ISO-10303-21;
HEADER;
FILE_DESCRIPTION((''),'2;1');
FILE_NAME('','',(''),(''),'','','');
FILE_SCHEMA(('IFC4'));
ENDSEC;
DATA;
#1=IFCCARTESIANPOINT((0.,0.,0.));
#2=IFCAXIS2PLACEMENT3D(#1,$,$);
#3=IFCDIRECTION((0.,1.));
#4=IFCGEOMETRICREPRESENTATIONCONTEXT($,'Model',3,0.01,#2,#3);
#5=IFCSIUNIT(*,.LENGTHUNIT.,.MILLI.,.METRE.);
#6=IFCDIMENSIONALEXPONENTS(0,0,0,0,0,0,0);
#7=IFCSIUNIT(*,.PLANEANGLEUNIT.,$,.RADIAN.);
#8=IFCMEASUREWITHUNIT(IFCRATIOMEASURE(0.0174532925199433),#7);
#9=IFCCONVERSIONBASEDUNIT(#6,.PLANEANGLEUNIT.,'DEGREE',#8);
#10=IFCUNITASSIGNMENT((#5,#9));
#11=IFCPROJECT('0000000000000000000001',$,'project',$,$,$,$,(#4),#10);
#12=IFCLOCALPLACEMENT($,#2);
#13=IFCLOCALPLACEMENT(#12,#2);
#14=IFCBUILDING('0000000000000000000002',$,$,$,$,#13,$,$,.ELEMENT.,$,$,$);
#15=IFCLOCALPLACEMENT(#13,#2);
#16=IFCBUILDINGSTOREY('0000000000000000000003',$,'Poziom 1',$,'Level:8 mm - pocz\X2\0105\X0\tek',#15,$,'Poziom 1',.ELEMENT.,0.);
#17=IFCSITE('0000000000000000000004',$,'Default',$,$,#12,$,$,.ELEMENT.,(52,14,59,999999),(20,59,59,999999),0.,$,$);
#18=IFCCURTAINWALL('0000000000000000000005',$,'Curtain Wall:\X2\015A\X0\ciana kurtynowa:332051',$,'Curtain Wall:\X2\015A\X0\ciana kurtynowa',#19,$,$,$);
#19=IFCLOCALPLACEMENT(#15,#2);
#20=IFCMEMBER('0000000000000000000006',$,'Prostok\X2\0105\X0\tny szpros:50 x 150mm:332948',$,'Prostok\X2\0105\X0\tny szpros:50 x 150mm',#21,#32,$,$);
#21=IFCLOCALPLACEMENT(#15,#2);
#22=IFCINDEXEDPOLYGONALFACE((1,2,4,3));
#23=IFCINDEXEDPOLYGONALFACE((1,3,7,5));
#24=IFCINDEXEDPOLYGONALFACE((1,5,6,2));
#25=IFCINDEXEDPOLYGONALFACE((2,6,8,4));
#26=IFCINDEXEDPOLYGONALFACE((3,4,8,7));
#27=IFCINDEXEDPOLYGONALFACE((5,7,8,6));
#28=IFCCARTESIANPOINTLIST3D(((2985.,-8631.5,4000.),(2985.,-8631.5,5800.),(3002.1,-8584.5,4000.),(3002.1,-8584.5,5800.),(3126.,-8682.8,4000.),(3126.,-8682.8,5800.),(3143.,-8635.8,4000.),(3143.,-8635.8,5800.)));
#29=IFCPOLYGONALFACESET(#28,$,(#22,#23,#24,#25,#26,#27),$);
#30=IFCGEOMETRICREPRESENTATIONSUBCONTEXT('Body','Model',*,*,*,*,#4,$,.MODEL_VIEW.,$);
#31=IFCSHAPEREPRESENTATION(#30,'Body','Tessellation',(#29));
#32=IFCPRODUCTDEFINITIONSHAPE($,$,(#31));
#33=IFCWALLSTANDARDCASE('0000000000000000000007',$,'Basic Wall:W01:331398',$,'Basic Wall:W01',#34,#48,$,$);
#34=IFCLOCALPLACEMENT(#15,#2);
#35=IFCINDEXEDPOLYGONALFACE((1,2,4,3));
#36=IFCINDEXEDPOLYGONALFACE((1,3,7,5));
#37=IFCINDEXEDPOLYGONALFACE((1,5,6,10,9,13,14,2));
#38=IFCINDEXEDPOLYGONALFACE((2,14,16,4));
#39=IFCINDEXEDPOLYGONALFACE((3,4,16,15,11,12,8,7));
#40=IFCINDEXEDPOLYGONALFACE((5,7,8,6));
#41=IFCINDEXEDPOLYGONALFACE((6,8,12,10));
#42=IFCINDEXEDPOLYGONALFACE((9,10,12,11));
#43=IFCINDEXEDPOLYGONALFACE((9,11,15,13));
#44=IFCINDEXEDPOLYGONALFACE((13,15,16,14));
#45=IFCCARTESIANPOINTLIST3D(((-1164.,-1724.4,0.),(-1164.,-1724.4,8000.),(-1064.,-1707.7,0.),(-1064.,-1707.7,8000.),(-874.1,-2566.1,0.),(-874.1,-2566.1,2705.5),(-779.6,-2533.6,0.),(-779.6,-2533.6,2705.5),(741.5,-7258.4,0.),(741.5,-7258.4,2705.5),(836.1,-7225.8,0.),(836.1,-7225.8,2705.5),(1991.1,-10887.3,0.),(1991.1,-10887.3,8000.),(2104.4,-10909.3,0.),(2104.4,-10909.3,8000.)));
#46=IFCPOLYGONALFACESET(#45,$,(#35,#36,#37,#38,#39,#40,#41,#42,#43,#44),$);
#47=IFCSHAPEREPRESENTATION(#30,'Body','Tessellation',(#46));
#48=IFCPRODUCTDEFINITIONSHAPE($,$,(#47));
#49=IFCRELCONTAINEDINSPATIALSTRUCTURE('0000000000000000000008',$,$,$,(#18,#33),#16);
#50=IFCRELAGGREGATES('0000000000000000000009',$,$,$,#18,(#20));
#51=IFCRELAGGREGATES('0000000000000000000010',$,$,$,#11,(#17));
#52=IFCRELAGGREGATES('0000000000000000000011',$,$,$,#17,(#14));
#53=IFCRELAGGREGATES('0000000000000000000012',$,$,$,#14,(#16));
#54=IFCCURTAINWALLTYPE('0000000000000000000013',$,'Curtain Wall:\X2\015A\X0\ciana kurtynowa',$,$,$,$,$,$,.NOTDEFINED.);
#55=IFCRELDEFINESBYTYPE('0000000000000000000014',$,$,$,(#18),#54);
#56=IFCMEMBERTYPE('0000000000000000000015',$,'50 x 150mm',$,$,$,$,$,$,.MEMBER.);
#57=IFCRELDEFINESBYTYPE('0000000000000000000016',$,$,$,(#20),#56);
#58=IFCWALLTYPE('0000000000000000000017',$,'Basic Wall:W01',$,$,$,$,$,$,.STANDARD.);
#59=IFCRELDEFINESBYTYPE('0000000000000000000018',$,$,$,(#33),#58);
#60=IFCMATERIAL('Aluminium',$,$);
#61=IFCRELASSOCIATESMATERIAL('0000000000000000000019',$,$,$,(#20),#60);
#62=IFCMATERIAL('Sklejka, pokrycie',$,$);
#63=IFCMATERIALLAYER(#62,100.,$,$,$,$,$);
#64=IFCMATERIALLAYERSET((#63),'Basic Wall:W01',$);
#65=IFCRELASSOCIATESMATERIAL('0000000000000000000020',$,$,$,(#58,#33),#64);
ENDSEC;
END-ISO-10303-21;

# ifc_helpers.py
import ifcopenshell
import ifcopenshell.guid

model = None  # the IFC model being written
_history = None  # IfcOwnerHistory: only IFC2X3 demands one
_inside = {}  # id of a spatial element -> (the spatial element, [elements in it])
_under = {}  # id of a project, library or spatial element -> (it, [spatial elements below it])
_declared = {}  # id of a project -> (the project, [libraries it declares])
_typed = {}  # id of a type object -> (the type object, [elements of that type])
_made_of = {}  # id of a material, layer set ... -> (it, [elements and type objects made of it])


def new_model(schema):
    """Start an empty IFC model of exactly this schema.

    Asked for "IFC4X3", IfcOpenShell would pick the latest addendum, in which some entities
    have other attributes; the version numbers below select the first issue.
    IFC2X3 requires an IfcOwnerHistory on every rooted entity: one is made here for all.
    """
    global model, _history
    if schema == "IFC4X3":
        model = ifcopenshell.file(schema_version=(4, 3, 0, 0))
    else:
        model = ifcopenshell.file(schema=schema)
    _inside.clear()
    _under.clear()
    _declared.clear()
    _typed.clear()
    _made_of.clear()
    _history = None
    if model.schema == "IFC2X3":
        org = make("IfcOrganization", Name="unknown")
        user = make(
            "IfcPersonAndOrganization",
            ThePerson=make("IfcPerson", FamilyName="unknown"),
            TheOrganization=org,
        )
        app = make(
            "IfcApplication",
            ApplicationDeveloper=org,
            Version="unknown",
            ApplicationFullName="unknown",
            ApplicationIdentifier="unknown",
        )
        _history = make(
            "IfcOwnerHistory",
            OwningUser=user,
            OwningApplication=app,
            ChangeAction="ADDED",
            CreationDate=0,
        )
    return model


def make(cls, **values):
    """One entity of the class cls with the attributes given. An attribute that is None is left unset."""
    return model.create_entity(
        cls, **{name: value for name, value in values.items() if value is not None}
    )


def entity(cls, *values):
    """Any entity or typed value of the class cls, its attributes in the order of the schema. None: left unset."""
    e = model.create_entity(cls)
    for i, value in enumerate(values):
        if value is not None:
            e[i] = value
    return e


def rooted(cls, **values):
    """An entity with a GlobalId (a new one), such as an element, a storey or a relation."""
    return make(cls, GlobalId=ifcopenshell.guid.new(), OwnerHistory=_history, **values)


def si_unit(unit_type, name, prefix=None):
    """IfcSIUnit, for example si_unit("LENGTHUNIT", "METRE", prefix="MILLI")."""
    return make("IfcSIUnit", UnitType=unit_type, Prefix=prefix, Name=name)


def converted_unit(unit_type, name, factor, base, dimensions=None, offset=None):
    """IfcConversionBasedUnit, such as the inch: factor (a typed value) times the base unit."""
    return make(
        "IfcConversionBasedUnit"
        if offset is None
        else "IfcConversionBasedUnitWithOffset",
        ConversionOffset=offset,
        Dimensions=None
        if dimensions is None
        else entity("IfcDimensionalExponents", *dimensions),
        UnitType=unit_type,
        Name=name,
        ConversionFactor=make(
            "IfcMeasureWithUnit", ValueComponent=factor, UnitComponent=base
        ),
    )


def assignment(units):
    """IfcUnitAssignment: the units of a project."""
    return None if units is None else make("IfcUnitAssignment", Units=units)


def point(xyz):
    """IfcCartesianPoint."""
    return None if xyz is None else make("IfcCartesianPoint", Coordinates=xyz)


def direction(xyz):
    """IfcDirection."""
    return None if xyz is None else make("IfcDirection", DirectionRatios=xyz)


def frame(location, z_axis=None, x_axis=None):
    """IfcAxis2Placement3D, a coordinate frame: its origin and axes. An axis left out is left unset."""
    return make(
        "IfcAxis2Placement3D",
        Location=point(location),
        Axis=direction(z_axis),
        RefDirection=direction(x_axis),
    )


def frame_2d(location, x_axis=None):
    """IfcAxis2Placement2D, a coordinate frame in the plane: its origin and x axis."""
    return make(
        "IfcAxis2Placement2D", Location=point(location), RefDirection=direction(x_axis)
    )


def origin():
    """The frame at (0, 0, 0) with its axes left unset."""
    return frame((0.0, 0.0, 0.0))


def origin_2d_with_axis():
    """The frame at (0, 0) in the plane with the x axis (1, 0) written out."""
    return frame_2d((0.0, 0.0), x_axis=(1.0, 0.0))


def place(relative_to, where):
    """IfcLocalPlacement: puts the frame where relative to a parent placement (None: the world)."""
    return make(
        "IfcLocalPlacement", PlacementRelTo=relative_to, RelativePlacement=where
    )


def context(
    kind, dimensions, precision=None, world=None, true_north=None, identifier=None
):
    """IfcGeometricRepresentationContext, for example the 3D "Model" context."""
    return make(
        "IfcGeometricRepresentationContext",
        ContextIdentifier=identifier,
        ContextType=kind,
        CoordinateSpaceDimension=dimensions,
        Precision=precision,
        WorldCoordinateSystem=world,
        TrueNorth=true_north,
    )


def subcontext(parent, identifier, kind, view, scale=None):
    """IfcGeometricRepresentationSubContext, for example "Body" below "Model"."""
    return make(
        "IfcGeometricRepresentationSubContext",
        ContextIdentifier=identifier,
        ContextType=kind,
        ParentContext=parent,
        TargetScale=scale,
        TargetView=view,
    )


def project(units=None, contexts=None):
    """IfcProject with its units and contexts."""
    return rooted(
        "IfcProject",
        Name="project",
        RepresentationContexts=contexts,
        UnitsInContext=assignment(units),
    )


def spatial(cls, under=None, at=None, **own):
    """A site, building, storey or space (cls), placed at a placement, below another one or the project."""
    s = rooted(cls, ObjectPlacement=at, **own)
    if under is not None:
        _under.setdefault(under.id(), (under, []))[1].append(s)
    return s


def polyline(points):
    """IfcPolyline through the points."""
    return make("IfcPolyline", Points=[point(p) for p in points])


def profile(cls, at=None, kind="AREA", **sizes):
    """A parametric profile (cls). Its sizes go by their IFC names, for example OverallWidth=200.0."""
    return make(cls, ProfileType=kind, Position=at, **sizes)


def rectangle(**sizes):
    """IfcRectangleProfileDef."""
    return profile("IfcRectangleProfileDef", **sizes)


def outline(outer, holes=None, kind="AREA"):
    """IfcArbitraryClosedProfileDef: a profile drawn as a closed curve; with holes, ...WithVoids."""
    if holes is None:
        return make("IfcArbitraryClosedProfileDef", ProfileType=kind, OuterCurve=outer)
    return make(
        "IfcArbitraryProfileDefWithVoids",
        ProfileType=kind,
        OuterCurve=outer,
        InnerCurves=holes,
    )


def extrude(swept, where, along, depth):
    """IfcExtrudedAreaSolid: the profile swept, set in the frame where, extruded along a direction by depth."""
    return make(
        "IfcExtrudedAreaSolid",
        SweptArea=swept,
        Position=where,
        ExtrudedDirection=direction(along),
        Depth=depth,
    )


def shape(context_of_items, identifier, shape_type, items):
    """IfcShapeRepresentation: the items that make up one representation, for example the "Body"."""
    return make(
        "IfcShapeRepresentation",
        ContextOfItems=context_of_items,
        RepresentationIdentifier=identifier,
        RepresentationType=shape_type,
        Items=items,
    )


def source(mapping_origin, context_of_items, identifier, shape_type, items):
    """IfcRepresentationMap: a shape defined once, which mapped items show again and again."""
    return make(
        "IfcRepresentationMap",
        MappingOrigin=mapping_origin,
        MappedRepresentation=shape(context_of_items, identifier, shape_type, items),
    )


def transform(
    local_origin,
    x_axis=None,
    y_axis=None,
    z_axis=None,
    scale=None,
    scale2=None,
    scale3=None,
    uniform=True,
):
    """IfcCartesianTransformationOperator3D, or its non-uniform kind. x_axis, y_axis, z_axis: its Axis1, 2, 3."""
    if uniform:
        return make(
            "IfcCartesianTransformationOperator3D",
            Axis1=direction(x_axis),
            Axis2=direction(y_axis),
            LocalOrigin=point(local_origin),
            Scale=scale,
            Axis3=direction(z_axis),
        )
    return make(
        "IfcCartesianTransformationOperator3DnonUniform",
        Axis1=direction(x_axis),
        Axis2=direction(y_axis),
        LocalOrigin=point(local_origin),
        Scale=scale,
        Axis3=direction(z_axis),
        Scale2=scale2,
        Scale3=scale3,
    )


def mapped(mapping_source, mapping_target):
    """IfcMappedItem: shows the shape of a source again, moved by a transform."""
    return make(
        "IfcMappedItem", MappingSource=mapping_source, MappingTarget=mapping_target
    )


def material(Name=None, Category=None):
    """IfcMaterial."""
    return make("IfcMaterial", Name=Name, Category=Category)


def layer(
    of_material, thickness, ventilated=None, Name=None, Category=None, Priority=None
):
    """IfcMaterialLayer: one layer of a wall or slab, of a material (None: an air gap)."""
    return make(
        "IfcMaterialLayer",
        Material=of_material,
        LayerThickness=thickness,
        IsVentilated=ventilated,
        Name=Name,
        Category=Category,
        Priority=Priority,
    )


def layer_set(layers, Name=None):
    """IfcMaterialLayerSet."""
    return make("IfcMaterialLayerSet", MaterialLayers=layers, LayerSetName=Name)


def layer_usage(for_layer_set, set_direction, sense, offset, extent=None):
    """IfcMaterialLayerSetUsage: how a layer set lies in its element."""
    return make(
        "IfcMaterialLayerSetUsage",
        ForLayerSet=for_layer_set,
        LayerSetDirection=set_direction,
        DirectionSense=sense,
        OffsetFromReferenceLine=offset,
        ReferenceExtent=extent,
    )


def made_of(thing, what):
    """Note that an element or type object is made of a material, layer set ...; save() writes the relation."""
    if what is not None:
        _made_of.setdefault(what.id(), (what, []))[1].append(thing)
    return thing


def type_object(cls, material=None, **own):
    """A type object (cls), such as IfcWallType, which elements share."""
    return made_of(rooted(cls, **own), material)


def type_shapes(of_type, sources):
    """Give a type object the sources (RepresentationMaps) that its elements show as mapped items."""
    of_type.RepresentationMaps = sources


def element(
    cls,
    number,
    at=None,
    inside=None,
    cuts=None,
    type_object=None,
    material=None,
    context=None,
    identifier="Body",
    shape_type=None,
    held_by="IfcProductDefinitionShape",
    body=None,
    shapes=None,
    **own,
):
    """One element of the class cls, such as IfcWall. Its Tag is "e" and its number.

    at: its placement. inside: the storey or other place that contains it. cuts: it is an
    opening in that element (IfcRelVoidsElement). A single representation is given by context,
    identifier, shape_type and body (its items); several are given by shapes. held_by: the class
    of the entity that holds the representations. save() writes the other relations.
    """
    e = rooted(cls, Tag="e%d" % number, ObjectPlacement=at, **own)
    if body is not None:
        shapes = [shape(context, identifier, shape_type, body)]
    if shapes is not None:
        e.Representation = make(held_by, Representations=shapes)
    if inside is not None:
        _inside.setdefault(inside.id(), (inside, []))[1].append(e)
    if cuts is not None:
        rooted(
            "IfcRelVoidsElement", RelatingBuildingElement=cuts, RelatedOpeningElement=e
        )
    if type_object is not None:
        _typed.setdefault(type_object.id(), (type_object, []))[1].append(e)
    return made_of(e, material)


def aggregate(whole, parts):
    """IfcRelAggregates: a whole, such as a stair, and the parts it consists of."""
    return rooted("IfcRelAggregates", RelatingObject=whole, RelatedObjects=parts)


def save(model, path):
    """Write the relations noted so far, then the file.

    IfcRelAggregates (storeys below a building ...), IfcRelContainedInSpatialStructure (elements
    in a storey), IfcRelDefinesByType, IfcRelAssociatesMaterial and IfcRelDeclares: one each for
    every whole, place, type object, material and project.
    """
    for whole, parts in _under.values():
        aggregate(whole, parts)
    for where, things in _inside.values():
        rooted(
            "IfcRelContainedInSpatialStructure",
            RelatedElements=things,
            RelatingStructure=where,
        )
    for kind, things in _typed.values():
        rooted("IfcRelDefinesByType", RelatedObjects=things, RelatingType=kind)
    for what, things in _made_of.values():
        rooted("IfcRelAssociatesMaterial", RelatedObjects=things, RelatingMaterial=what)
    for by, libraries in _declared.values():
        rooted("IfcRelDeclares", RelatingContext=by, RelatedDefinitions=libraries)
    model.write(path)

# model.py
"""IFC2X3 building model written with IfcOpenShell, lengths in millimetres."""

from ifc_helpers import new_model, entity, si_unit, converted_unit, direction, frame, frame_2d, origin, origin_2d_with_axis, place, context, subcontext, project, spatial, polyline, rectangle, outline, extrude, source, transform, mapped, material, layer, layer_set, layer_usage, type_object, type_shapes, element, aggregate, save


model = new_model("IFC2X3")

# Units and contexts
model_context = context("Model", 3, precision=0.01, world=origin(), true_north=direction((0.0, 1.0)))
body_context = subcontext(model_context, "Body", "Model", "MODEL_VIEW")
ifc_project = project(units=[si_unit("LENGTHUNIT", "METRE", prefix="MILLI"), converted_unit("PLANEANGLEUNIT", "DEGREE", entity("IfcRatioMeasure", 0.0174532925199433), si_unit("PLANEANGLEUNIT", "RADIAN"), dimensions=[0, 0, 0, 0, 0, 0, 0])], contexts=[model_context])

# Site, building, storey
site_placement = place(None, origin())
site = spatial("IfcSite", under=ifc_project, at=site_placement, Name="Default", CompositionType="ELEMENT", RefLatitude=(52, 14, 59, 999999), RefLongitude=(20, 59, 59, 999999), RefElevation=0.0)
building_placement = place(site_placement, origin())
building = spatial("IfcBuilding", under=site, at=building_placement, CompositionType="ELEMENT")
storey_placement = place(building_placement, origin())
storey = spatial("IfcBuildingStorey", under=building, at=storey_placement, Name="Poziom 1", ObjectType="Level:8 mm - początek", LongName="Poziom 1", CompositionType="ELEMENT", Elevation=0.0)

# Curtain wall, member
curtain_wall_type = type_object("IfcCurtainWallType", Name="Curtain Wall:Ściana kurtynowa", PredefinedType="NOTDEFINED")
curtain_wall_placement = place(storey_placement, origin())
curtain_wall = element("IfcCurtainWall", 1, at=curtain_wall_placement, inside=storey, type_object=curtain_wall_type, Name="Curtain Wall:Ściana kurtynowa:332051", ObjectType="Curtain Wall:Ściana kurtynowa")
ifc_material_1 = material(Name="Aluminium")
member_type_1 = type_object("IfcMemberType", Name="50 x 150mm", PredefinedType="MEMBER")
shared_shape_1 = source(origin(), body_context, "Body", "SweptSolid", [
    extrude(rectangle(XDim=150.0, YDim=50.0, at=origin_2d_with_axis()), frame((0.0, 0.0, -1800.0), z_axis=(0.0, 0.0, 1.0), x_axis=(0.0, -1.0, 0.0)), (0.0, 0.0, 1.0), 1800.0),
])
type_shapes(member_type_1, [shared_shape_1])
member_1_placement = place(storey_placement, frame((3064.0, -8633.7, 4000.0), z_axis=(0.0, 0.0, -1.0), x_axis=(0.341586, 0.939851, 0.0)))
member_1 = element("IfcMember", 2, at=member_1_placement, type_object=member_type_1, material=ifc_material_1, Name="Prostokątny szpros:50 x 150mm:332948", ObjectType="Prostokątny szpros:50 x 150mm", context=body_context, shape_type="MappedRepresentation", body=[
    mapped(shared_shape_1, transform((0.0, 0.0, 0.0), scale=1.0)),
])
aggregate(curtain_wall, [member_1])

# Wall, opening
ifc_material_2 = material(Name="Sklejka, pokrycie")
ifc_layer_1 = layer(ifc_material_2, 100.0)
ifc_layer_set_1 = layer_set([ifc_layer_1], Name="Basic Wall:W01")
ifc_layer_usage_1 = layer_usage(ifc_layer_set_1, "AXIS2", "NEGATIVE", 50.0)
wall_type_1 = type_object("IfcWallType", Name="Basic Wall:W01", PredefinedType="STANDARD", material=ifc_layer_set_1)
wall_1_placement = place(storey_placement, frame((2057.1, -10925.6, 0.0), z_axis=(0.0, 0.0, 1.0), x_axis=(-0.325568, 0.945519, 0.0)))
wall_1 = element("IfcWallStandardCase", 3, at=wall_1_placement, inside=storey, type_object=wall_type_1, material=ifc_layer_usage_1, Name="Basic Wall:W01:331398", ObjectType="Basic Wall:W01", context=body_context, shape_type="SweptSolid", body=[
    extrude(outline(polyline([(0.0, -50.0), (9731.8, -50.0), (9748.6, 50.0), (57.7, 50.0), (0.0, -50.0)])), origin(), (0.0, 0.0, 1.0), 8000.0),
])
opening_1_placement = place(wall_1_placement, origin())
element("IfcOpeningElement", 4, at=opening_1_placement, cuts=wall_1, ObjectType="Opening", context=body_context, shape_type="SweptSolid", body=[
    extrude(rectangle(XDim=2714.3, YDim=4962.6, at=frame_2d((0.0, 0.0), x_axis=(1.0, 0.0))), frame((6377.1, -50.0, 1348.3), z_axis=(0.0, 1.0, 0.0), x_axis=(0.0, 0.0, -1.0)), (0.0, 0.0, 1.0), 100.0),
])

save(model, "model.ifc")
